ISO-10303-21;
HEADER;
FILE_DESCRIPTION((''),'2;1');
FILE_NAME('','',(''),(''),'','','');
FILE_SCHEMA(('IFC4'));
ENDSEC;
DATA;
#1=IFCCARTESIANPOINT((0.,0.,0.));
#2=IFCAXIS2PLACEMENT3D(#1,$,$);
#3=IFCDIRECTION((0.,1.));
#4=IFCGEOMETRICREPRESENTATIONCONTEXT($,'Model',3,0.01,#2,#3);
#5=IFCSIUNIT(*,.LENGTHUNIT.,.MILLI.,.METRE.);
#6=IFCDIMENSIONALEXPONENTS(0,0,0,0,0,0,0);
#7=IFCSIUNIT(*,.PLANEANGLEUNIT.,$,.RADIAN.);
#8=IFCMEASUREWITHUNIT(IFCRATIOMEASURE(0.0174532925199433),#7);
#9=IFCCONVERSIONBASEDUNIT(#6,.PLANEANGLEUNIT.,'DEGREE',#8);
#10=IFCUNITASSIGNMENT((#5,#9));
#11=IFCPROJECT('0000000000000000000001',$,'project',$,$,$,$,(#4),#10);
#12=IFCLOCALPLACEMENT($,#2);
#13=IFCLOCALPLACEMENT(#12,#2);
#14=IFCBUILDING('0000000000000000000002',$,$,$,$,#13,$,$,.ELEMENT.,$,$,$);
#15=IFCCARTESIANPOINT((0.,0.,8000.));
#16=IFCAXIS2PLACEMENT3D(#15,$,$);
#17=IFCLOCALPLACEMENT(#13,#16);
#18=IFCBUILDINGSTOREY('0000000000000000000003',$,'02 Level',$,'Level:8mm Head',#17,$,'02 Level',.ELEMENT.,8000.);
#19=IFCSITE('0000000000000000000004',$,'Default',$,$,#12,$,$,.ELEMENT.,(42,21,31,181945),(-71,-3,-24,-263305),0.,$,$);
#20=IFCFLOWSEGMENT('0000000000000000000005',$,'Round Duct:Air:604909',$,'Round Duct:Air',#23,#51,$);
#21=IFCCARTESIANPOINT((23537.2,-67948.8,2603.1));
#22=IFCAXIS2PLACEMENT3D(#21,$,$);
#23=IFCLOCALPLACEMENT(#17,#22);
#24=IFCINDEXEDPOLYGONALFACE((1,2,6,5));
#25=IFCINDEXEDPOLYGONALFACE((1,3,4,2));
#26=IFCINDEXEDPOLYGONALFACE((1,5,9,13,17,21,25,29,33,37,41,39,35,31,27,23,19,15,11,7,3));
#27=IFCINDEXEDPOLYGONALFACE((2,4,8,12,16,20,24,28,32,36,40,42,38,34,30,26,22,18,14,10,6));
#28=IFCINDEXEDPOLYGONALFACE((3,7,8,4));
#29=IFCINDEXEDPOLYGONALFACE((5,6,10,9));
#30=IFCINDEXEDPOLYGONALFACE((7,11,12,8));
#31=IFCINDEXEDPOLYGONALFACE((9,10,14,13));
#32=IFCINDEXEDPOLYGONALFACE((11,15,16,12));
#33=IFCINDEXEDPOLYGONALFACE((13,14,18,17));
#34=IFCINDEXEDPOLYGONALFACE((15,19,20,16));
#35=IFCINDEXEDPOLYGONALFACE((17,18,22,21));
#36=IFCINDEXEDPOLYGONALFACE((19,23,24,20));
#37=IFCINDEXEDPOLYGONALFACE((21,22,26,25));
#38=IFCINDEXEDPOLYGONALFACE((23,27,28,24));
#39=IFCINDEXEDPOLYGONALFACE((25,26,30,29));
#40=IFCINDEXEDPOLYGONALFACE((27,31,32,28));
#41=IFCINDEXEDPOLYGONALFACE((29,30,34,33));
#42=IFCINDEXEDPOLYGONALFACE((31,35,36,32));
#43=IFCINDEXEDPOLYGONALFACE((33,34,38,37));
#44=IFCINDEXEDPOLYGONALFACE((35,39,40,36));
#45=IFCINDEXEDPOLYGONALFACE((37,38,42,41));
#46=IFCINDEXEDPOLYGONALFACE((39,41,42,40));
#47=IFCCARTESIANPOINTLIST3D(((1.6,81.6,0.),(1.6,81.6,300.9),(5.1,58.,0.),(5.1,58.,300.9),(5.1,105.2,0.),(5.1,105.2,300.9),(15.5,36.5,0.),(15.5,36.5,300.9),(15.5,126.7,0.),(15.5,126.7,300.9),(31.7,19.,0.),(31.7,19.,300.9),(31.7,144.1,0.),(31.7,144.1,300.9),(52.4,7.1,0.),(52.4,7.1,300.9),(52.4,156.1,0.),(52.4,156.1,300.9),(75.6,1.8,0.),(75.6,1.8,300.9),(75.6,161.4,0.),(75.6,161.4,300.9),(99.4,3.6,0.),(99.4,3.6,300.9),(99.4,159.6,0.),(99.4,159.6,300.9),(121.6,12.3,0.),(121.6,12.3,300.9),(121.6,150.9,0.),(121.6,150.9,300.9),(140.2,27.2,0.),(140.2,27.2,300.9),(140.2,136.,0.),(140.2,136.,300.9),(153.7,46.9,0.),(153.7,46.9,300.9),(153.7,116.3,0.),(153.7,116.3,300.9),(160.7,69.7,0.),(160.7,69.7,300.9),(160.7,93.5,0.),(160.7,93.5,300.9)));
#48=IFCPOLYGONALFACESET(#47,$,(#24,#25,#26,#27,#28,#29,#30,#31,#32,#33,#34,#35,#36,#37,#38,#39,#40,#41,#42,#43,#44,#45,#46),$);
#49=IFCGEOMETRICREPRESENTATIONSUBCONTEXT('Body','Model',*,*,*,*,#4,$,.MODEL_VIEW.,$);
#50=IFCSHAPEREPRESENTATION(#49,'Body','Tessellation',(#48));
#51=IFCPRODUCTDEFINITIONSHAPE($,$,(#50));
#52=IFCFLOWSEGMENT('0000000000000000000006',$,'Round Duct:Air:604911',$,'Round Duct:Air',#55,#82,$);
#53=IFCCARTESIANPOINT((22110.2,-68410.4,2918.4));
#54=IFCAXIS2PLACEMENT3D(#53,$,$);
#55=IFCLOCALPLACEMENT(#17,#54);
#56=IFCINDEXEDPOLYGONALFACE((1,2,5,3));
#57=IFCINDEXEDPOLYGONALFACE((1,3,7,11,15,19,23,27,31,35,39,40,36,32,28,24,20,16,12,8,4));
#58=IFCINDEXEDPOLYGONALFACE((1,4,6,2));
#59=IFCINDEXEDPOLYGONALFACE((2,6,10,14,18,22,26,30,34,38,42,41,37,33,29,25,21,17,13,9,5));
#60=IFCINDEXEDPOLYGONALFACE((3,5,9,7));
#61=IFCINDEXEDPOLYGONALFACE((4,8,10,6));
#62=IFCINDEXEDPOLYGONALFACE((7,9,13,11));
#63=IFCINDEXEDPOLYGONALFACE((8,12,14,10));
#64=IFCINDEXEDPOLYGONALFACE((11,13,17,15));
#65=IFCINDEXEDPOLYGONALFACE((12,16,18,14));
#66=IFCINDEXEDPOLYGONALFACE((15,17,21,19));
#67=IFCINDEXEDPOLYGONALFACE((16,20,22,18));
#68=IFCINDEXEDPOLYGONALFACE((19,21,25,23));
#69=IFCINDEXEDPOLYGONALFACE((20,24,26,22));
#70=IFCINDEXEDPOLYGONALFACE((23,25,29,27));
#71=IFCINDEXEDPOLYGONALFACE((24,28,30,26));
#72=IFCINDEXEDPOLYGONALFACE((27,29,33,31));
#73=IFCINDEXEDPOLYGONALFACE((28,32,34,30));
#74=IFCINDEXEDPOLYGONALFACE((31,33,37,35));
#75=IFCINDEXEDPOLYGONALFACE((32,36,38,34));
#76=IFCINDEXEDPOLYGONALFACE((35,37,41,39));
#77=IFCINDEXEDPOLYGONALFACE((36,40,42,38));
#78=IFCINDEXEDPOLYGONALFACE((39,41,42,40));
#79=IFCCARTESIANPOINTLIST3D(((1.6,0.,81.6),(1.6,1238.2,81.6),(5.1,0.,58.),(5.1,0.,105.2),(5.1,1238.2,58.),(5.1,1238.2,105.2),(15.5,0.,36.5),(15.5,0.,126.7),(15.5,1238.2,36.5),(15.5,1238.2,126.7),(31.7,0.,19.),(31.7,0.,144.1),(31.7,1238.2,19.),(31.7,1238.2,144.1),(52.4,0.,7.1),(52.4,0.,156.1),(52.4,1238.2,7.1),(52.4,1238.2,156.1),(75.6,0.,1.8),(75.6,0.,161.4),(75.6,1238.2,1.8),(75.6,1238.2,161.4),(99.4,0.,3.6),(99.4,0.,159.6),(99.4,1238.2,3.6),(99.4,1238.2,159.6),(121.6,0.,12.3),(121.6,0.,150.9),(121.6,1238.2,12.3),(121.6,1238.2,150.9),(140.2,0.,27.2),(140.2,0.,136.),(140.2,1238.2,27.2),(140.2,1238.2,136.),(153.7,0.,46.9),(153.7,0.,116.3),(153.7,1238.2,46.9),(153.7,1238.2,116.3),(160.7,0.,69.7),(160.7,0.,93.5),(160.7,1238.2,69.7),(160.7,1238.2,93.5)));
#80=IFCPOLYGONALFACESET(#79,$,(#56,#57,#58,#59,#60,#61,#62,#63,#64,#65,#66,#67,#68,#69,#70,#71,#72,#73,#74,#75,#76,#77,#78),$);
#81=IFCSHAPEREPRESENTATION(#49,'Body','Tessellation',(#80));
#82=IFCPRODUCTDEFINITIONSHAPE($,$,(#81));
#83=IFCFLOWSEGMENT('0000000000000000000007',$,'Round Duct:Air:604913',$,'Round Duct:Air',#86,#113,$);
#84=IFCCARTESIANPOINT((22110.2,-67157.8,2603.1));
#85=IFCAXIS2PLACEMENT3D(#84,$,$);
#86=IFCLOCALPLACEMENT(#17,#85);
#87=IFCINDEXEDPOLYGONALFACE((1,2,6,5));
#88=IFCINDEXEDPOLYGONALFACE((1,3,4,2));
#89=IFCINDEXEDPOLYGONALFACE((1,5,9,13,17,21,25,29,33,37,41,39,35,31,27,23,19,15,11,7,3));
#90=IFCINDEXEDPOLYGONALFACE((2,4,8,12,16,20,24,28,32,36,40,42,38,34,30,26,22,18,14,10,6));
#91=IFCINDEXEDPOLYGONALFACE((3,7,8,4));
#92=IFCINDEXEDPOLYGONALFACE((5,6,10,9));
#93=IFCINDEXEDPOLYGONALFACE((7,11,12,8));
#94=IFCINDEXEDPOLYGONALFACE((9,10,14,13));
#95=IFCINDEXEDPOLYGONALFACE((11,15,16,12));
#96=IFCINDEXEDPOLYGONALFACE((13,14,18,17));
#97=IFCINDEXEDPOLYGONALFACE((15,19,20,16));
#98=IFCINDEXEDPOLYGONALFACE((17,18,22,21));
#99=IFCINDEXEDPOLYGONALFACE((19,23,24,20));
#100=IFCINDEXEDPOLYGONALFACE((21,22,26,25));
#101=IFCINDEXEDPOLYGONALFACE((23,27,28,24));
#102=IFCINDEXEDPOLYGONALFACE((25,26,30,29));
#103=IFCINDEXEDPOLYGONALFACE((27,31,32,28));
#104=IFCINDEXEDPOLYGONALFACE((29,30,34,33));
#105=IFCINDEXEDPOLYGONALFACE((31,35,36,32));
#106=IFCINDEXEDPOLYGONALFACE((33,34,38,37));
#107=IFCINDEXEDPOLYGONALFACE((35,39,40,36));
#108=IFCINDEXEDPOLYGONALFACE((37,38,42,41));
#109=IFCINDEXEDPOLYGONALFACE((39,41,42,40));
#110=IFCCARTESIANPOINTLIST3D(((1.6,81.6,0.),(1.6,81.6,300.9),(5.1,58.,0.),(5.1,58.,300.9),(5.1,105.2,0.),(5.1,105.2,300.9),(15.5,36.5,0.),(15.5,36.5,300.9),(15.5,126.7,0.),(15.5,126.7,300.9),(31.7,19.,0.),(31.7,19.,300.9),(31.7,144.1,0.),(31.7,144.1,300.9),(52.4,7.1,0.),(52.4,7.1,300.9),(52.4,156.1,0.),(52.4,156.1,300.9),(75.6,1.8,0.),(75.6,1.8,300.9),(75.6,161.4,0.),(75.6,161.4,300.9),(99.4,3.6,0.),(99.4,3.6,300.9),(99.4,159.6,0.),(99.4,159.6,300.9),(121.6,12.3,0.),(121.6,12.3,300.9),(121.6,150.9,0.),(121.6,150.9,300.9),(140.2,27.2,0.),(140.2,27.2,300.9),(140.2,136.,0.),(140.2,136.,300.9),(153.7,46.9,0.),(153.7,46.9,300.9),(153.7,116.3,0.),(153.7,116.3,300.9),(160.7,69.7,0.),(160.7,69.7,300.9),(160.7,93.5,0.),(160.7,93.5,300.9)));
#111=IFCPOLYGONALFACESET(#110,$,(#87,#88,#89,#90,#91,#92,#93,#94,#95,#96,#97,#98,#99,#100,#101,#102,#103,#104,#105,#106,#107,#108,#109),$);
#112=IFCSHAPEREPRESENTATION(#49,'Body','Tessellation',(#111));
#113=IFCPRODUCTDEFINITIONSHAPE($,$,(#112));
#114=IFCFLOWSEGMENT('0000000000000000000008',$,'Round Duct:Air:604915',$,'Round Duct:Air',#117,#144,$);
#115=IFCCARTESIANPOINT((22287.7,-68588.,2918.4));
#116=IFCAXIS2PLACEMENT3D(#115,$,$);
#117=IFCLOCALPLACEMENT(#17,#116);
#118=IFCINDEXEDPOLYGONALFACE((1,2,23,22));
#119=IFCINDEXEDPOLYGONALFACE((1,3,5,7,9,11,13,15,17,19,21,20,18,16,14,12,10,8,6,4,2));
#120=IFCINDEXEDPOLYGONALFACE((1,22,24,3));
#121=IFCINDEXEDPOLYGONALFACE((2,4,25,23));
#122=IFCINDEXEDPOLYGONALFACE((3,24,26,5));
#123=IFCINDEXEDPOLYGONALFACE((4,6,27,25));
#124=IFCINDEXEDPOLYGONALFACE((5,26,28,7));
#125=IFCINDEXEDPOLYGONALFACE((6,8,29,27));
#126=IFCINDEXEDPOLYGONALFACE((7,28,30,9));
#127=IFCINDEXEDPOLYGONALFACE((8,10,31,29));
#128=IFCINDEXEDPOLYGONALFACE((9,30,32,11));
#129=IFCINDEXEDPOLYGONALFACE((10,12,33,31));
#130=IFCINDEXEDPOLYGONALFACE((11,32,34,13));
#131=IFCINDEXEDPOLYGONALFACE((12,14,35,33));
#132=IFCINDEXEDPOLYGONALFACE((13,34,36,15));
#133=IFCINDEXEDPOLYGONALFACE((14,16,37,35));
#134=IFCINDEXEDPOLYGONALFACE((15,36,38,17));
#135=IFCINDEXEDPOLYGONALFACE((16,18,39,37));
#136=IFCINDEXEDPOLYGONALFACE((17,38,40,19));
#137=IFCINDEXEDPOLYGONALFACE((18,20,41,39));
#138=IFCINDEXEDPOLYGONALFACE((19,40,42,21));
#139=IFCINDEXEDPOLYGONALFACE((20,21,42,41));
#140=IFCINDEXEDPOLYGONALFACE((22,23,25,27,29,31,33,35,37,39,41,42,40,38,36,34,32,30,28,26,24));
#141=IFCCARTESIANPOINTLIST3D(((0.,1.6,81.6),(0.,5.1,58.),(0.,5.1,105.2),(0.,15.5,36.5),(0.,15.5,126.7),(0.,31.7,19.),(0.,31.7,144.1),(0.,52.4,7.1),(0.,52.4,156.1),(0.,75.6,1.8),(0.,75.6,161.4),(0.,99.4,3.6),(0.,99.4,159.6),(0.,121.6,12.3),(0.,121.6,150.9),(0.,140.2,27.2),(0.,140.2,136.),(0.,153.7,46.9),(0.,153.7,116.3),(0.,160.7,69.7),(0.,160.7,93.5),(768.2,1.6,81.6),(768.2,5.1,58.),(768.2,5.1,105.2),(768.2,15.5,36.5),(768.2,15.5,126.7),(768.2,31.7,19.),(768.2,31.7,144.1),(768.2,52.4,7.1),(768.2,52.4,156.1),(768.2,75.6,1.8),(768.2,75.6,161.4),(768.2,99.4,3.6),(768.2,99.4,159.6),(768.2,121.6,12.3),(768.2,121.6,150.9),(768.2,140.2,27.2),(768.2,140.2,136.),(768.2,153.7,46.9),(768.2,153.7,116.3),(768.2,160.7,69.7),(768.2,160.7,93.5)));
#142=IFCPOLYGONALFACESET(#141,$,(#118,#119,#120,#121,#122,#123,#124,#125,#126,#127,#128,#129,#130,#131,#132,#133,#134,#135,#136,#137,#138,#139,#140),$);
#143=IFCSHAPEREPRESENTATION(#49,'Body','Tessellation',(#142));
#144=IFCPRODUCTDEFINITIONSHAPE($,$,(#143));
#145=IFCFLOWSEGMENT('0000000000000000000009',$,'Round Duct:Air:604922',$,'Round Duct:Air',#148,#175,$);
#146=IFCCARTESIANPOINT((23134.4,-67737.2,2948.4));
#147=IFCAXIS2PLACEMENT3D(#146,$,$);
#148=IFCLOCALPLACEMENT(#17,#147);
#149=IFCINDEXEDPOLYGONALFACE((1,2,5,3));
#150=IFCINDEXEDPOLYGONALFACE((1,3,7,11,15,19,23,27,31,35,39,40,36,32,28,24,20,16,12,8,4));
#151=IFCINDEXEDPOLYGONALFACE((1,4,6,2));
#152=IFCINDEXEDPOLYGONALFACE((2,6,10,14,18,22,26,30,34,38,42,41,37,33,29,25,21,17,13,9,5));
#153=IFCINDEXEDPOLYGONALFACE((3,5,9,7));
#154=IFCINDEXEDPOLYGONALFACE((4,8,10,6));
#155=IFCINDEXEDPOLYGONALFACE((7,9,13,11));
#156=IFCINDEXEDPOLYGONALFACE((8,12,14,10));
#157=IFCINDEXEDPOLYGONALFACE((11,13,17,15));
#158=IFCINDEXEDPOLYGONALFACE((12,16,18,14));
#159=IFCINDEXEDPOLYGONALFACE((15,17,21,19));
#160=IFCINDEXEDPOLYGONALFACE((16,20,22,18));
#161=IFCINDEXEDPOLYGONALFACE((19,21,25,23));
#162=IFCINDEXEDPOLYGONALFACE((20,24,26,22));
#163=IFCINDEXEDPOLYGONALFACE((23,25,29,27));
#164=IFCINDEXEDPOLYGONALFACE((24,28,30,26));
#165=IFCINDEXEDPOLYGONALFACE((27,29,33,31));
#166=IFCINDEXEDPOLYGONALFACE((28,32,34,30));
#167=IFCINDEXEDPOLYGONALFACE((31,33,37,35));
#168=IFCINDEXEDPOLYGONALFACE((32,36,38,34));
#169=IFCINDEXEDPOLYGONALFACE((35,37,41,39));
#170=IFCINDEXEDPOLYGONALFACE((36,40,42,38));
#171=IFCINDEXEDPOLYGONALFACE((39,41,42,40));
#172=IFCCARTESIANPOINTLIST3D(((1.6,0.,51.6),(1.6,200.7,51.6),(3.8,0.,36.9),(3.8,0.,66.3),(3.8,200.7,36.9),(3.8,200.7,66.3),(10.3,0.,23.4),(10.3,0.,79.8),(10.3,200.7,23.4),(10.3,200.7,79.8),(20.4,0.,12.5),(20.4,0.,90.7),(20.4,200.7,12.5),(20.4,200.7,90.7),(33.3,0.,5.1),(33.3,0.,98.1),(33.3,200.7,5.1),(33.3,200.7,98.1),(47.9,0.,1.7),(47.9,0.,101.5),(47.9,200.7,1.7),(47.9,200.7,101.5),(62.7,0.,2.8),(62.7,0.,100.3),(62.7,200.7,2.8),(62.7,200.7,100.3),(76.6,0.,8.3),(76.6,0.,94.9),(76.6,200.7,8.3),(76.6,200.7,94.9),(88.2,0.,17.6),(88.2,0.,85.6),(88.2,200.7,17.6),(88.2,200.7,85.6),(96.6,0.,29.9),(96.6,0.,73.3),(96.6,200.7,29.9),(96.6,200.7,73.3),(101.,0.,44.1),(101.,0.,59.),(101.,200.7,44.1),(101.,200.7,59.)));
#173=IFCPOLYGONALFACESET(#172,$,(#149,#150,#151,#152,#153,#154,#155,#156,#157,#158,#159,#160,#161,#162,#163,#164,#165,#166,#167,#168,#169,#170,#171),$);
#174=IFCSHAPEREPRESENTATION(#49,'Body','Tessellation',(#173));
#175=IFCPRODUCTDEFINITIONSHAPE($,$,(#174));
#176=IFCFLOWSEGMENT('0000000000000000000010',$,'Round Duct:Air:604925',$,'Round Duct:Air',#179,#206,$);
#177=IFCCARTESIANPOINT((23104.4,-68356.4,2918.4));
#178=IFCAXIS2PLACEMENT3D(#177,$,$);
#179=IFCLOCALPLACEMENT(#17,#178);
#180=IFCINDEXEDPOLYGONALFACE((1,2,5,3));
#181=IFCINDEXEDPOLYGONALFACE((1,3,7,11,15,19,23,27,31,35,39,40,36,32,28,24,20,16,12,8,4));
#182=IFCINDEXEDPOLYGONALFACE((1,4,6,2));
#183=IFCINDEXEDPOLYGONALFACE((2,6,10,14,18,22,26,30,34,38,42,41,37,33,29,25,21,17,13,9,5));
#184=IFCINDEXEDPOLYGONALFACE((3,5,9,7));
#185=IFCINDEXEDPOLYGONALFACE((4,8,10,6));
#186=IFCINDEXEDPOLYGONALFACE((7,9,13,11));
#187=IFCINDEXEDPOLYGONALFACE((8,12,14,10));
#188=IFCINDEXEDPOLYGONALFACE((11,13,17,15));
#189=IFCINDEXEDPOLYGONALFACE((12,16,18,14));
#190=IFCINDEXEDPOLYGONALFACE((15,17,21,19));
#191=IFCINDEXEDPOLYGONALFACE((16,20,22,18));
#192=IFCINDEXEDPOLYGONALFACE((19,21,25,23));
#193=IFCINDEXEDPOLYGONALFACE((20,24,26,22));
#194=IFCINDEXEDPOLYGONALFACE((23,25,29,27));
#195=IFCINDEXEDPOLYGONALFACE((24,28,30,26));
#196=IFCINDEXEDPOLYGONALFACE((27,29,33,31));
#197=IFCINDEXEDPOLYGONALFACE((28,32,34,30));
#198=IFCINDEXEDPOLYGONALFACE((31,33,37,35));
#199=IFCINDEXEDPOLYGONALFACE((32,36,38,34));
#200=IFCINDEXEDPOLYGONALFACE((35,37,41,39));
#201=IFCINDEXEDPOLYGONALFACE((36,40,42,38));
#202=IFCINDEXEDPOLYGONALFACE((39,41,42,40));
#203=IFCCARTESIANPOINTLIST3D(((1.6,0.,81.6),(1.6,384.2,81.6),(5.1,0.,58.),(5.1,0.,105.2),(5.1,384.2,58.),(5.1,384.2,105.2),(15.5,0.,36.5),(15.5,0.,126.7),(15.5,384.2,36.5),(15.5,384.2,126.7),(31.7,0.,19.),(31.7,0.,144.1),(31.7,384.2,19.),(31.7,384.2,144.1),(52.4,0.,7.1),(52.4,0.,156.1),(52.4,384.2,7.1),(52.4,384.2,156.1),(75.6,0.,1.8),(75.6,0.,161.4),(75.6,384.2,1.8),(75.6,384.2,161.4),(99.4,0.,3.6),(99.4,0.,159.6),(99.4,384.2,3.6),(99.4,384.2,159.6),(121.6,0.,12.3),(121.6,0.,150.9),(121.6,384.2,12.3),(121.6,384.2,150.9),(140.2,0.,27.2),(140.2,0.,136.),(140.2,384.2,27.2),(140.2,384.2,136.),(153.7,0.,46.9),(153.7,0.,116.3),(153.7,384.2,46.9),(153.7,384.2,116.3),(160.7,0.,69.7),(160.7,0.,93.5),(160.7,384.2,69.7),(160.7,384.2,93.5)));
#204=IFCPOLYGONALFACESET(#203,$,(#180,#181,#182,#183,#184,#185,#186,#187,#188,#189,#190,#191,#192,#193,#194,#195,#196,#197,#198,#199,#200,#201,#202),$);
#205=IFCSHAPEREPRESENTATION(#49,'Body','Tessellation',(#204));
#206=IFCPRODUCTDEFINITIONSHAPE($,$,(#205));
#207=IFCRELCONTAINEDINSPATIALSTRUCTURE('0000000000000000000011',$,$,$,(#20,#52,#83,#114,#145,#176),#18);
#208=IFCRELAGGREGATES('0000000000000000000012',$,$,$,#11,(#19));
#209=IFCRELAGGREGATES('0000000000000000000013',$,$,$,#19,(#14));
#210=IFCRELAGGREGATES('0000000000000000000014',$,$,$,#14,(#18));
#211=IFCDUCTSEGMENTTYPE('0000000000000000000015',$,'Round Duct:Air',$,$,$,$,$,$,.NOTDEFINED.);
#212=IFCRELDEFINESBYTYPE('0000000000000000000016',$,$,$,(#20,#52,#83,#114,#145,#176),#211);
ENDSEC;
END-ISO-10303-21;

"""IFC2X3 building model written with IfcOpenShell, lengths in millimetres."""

from ifc_helpers import new_model, entity, si_unit, converted_unit, direction, frame, frame_2d, origin, origin_2d_with_axis, place, context, subcontext, project, spatial, circle, extrude, type_object, element, save


model = new_model("IFC2X3")

# Units and contexts
model_context = context("Model", 3, precision=0.01, world=origin(), true_north=direction((0.0, 1.0)))
body_context = subcontext(model_context, "Body", "Model", "MODEL_VIEW")
ifc_project = project(units=[si_unit("LENGTHUNIT", "METRE", prefix="MILLI"), converted_unit("PLANEANGLEUNIT", "DEGREE", entity("IfcRatioMeasure", 0.0174532925199433), si_unit("PLANEANGLEUNIT", "RADIAN"), dimensions=[0, 0, 0, 0, 0, 0, 0])], contexts=[model_context])

# Site, building, storey
site_placement = place(None, origin())
site = spatial("IfcSite", under=ifc_project, at=site_placement, Name="Default", CompositionType="ELEMENT", RefLatitude=(42, 21, 31, 181945), RefLongitude=(-71, -3, -24, -263305), RefElevation=0.0)
building_placement = place(site_placement, origin())
building = spatial("IfcBuilding", under=site, at=building_placement, CompositionType="ELEMENT")
storey_placement = place(building_placement, frame((0.0, 0.0, 8000.0)))
storey = spatial("IfcBuildingStorey", under=building, at=storey_placement, Name="02 Level", ObjectType="Level:8mm Head", LongName="02 Level", CompositionType="ELEMENT", Elevation=8000.0)

# Flow segments
duct_segment_type_1 = type_object("IfcDuctSegmentType", Name="Round Duct:Air", PredefinedType="NOTDEFINED")
flow_segment_1_placement = place(storey_placement, frame((23537.2, -67948.8, 2603.1)))
element("IfcFlowSegment", 1, at=flow_segment_1_placement, inside=storey, type_object=duct_segment_type_1, Name="Round Duct:Air:604909", ObjectType="Round Duct:Air", context=body_context, shape_type="SweptSolid", body=[
    extrude(circle(Radius=80.0, at=origin_2d_with_axis()), frame((81.6, 81.6, 0.0), z_axis=(0.0, 0.0, 1.0), x_axis=(-1.0, 0.0, 0.0)), (0.0, 0.0, 1.0), 300.9),
])
flow_segment_2_placement = place(storey_placement, frame((22110.2, -68410.4, 2918.4)))
element("IfcFlowSegment", 2, at=flow_segment_2_placement, inside=storey, type_object=duct_segment_type_1, Name="Round Duct:Air:604911", ObjectType="Round Duct:Air", context=body_context, shape_type="SweptSolid", body=[
    extrude(circle(Radius=80.0, at=frame_2d((0.0, 0.0), x_axis=(1.0, 0.0))), frame((81.6, 0.0, 81.6), z_axis=(0.0, 1.0, 0.0), x_axis=(-1.0, 0.0, 0.0)), (0.0, 0.0, 1.0), 1238.2),
])
flow_segment_3_placement = place(storey_placement, frame((22110.2, -67157.8, 2603.1)))
element("IfcFlowSegment", 3, at=flow_segment_3_placement, inside=storey, type_object=duct_segment_type_1, Name="Round Duct:Air:604913", ObjectType="Round Duct:Air", context=body_context, shape_type="SweptSolid", body=[
    extrude(circle(Radius=80.0, at=origin_2d_with_axis()), frame((81.6, 81.6, 0.0), z_axis=(0.0, 0.0, 1.0), x_axis=(-1.0, 0.0, 0.0)), (0.0, 0.0, 1.0), 300.9),
])
flow_segment_4_placement = place(storey_placement, frame((22287.7, -68588.0, 2918.4)))
element("IfcFlowSegment", 4, at=flow_segment_4_placement, inside=storey, type_object=duct_segment_type_1, Name="Round Duct:Air:604915", ObjectType="Round Duct:Air", context=body_context, shape_type="SweptSolid", body=[
    extrude(circle(Radius=80.0, at=origin_2d_with_axis()), frame((0.0, 81.6, 81.6), z_axis=(1.0, 0.0, 0.0), x_axis=(0.0, -1.0, 0.0)), (0.0, 0.0, 1.0), 768.2),
])
flow_segment_5_placement = place(storey_placement, frame((23134.4, -67737.2, 2948.4)))
element("IfcFlowSegment", 5, at=flow_segment_5_placement, inside=storey, type_object=duct_segment_type_1, Name="Round Duct:Air:604922", ObjectType="Round Duct:Air", context=body_context, shape_type="SweptSolid", body=[
    extrude(circle(Radius=50.0, at=origin_2d_with_axis()), frame((51.6, 0.0, 51.6), z_axis=(0.0, 1.0, 0.0), x_axis=(-1.0, 0.0, 0.0)), (0.0, 0.0, 1.0), 200.7),
])
flow_segment_6_placement = place(storey_placement, frame((23104.4, -68356.4, 2918.4)))
element("IfcFlowSegment", 6, at=flow_segment_6_placement, inside=storey, type_object=duct_segment_type_1, Name="Round Duct:Air:604925", ObjectType="Round Duct:Air", context=body_context, shape_type="SweptSolid", body=[
    extrude(circle(Radius=80.0, at=origin_2d_with_axis()), frame((81.6, 0.0, 81.6), z_axis=(0.0, 1.0, 0.0), x_axis=(-1.0, 0.0, 0.0)), (0.0, 0.0, 1.0), 384.2),
])

save(model, "model.ifc")
